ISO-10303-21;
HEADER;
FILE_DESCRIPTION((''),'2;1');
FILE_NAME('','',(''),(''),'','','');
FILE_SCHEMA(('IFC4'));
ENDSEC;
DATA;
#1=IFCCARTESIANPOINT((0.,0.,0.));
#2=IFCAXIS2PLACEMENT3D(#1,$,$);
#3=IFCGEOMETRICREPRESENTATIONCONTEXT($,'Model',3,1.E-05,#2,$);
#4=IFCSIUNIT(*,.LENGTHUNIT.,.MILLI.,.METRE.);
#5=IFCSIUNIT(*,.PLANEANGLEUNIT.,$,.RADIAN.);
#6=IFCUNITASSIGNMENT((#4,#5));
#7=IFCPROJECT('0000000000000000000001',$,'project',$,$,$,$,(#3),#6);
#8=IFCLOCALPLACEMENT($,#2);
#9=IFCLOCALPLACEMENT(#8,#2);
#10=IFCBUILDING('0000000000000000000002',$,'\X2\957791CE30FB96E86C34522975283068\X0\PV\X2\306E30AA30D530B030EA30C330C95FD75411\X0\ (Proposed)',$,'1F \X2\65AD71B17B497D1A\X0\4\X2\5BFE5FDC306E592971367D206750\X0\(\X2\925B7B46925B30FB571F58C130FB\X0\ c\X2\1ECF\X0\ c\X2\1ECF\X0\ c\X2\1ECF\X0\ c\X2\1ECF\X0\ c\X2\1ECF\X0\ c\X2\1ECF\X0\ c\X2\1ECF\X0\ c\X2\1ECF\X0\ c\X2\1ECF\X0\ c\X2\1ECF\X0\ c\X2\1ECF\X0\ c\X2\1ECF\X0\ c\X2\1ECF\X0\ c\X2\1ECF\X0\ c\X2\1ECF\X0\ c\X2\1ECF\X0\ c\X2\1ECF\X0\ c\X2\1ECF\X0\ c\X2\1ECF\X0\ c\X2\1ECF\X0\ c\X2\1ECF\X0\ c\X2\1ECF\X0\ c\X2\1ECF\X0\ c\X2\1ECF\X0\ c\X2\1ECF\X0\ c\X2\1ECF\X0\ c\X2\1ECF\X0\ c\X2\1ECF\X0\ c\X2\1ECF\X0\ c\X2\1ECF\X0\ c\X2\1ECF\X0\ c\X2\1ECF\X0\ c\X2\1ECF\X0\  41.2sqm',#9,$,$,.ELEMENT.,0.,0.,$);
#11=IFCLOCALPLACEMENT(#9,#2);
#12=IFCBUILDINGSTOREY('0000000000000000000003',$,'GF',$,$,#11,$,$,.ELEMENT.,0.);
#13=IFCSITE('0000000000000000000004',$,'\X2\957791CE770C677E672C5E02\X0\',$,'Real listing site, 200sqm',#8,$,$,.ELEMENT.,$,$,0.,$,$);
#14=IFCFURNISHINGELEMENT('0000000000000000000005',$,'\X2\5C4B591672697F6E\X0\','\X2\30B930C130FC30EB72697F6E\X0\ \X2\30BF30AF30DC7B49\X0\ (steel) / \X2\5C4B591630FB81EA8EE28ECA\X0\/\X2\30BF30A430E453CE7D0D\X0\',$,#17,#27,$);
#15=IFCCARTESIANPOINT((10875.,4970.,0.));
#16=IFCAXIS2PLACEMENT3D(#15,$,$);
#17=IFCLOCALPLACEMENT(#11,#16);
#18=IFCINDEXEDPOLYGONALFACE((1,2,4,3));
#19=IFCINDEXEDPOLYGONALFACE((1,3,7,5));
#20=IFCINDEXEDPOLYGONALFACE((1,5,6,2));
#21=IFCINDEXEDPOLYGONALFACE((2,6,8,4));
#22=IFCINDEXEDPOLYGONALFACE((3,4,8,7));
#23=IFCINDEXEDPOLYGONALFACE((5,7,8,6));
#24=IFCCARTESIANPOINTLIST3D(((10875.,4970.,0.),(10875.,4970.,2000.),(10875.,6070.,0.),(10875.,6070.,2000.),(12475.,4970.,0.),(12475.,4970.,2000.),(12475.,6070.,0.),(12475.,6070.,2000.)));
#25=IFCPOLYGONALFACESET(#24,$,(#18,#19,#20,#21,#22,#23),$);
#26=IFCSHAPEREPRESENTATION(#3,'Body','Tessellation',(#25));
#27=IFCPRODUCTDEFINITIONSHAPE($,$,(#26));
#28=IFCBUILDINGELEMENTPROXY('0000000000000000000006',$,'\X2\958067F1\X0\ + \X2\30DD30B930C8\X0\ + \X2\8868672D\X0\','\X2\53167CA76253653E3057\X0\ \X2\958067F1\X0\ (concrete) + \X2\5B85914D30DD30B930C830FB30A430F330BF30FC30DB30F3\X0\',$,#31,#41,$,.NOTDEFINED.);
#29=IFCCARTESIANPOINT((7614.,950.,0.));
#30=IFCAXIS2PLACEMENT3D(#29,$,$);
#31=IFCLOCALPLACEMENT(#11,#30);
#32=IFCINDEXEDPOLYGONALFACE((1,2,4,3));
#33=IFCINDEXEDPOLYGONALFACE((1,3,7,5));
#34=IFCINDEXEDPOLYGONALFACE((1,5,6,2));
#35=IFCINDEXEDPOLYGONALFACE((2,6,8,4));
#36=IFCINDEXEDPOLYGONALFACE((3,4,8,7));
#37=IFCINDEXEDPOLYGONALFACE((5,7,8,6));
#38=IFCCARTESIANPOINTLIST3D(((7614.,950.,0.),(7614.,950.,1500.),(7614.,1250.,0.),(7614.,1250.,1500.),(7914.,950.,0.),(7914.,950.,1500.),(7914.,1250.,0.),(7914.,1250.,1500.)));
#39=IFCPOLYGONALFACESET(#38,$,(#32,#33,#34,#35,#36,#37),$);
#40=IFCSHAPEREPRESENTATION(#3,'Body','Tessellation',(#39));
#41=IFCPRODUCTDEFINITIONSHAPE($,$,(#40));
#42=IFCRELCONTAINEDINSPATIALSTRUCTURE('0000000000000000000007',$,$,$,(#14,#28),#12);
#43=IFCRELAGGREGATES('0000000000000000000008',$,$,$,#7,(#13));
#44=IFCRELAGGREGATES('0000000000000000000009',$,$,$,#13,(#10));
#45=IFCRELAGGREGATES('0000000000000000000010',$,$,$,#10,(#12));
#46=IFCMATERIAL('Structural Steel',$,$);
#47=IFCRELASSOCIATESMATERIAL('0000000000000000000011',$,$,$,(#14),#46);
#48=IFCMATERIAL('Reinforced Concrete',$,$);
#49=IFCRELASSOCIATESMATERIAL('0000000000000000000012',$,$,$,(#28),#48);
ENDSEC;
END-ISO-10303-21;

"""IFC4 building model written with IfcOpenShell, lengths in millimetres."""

from ifc_helpers import new_model, si_unit, frame, frame_2d, origin, place, context, project, spatial, rectangle, extrude, material, element, save


model = new_model("IFC4")

# Units and contexts
model_context = context("Model", 3, precision=1e-05, world=origin())
ifc_project = project(units=[si_unit("LENGTHUNIT", "METRE", prefix="MILLI"), si_unit("PLANEANGLEUNIT", "RADIAN")], contexts=[model_context])

# Site, building, storey
site_placement = place(None, origin())
site = spatial("IfcSite", under=ifc_project, at=site_placement, Name="長野県松本市", ObjectType="Real listing site, 200sqm", CompositionType="ELEMENT", RefElevation=0.0)
building_placement = place(site_placement, origin())
building = spatial("IfcBuilding", under=site, at=building_placement, Name="長野・雨水利用とPVのオフグリッド志向 (Proposed)", ObjectType="1F 断熱等級4対応の天然素材(鉛筆鉛・土壁・ cỏ cỏ cỏ cỏ cỏ cỏ cỏ cỏ cỏ cỏ cỏ cỏ cỏ cỏ cỏ cỏ cỏ cỏ cỏ cỏ cỏ cỏ cỏ cỏ cỏ cỏ cỏ cỏ cỏ cỏ cỏ cỏ cỏ  41.2sqm", CompositionType="ELEMENT", ElevationOfRefHeight=0.0, ElevationOfTerrain=0.0)
storey_placement = place(building_placement, origin())
storey = spatial("IfcBuildingStorey", under=building, at=storey_placement, Name="GF", CompositionType="ELEMENT", Elevation=0.0)

# Shared definitions
ifc_material_1 = material(Name="Reinforced Concrete")

# Shared definitions
ifc_material_2 = material(Name="Structural Steel")

# Furnishing element
furnishing_1_placement = place(storey_placement, frame((10875.0, 4970.0, 0.0)))
element("IfcFurnishingElement", 1, at=furnishing_1_placement, inside=storey, material=ifc_material_2, Name="屋外物置", Description="スチール物置 タクボ等 (steel) / 屋外・自転車/タイヤ収納", context=model_context, shape_type="SweptSolid", body=[
    extrude(rectangle(XDim=1600.0, YDim=1100.0, at=frame_2d((800.0, 550.0))), frame((10875.0, 4970.0, 0.0)), (0.0, 0.0, 1.0), 2000.0),
])

# Building element proxy
proxy_placement = place(storey_placement, frame((7614.0, 950.0, 0.0)))
element("IfcBuildingElementProxy", 2, at=proxy_placement, inside=storey, material=ifc_material_1, Name="門柱 + ポスト + 表札", Description="化粧打放し 門柱 (concrete) + 宅配ポスト・インターホン", PredefinedType="NOTDEFINED", context=model_context, shape_type="SweptSolid", body=[
    extrude(rectangle(XDim=300.0, YDim=300.0, at=frame_2d((150.0, 150.0))), frame((7614.0, 950.0, 0.0)), (0.0, 0.0, 1.0), 1500.0),
])

save(model, "model.ifc")
